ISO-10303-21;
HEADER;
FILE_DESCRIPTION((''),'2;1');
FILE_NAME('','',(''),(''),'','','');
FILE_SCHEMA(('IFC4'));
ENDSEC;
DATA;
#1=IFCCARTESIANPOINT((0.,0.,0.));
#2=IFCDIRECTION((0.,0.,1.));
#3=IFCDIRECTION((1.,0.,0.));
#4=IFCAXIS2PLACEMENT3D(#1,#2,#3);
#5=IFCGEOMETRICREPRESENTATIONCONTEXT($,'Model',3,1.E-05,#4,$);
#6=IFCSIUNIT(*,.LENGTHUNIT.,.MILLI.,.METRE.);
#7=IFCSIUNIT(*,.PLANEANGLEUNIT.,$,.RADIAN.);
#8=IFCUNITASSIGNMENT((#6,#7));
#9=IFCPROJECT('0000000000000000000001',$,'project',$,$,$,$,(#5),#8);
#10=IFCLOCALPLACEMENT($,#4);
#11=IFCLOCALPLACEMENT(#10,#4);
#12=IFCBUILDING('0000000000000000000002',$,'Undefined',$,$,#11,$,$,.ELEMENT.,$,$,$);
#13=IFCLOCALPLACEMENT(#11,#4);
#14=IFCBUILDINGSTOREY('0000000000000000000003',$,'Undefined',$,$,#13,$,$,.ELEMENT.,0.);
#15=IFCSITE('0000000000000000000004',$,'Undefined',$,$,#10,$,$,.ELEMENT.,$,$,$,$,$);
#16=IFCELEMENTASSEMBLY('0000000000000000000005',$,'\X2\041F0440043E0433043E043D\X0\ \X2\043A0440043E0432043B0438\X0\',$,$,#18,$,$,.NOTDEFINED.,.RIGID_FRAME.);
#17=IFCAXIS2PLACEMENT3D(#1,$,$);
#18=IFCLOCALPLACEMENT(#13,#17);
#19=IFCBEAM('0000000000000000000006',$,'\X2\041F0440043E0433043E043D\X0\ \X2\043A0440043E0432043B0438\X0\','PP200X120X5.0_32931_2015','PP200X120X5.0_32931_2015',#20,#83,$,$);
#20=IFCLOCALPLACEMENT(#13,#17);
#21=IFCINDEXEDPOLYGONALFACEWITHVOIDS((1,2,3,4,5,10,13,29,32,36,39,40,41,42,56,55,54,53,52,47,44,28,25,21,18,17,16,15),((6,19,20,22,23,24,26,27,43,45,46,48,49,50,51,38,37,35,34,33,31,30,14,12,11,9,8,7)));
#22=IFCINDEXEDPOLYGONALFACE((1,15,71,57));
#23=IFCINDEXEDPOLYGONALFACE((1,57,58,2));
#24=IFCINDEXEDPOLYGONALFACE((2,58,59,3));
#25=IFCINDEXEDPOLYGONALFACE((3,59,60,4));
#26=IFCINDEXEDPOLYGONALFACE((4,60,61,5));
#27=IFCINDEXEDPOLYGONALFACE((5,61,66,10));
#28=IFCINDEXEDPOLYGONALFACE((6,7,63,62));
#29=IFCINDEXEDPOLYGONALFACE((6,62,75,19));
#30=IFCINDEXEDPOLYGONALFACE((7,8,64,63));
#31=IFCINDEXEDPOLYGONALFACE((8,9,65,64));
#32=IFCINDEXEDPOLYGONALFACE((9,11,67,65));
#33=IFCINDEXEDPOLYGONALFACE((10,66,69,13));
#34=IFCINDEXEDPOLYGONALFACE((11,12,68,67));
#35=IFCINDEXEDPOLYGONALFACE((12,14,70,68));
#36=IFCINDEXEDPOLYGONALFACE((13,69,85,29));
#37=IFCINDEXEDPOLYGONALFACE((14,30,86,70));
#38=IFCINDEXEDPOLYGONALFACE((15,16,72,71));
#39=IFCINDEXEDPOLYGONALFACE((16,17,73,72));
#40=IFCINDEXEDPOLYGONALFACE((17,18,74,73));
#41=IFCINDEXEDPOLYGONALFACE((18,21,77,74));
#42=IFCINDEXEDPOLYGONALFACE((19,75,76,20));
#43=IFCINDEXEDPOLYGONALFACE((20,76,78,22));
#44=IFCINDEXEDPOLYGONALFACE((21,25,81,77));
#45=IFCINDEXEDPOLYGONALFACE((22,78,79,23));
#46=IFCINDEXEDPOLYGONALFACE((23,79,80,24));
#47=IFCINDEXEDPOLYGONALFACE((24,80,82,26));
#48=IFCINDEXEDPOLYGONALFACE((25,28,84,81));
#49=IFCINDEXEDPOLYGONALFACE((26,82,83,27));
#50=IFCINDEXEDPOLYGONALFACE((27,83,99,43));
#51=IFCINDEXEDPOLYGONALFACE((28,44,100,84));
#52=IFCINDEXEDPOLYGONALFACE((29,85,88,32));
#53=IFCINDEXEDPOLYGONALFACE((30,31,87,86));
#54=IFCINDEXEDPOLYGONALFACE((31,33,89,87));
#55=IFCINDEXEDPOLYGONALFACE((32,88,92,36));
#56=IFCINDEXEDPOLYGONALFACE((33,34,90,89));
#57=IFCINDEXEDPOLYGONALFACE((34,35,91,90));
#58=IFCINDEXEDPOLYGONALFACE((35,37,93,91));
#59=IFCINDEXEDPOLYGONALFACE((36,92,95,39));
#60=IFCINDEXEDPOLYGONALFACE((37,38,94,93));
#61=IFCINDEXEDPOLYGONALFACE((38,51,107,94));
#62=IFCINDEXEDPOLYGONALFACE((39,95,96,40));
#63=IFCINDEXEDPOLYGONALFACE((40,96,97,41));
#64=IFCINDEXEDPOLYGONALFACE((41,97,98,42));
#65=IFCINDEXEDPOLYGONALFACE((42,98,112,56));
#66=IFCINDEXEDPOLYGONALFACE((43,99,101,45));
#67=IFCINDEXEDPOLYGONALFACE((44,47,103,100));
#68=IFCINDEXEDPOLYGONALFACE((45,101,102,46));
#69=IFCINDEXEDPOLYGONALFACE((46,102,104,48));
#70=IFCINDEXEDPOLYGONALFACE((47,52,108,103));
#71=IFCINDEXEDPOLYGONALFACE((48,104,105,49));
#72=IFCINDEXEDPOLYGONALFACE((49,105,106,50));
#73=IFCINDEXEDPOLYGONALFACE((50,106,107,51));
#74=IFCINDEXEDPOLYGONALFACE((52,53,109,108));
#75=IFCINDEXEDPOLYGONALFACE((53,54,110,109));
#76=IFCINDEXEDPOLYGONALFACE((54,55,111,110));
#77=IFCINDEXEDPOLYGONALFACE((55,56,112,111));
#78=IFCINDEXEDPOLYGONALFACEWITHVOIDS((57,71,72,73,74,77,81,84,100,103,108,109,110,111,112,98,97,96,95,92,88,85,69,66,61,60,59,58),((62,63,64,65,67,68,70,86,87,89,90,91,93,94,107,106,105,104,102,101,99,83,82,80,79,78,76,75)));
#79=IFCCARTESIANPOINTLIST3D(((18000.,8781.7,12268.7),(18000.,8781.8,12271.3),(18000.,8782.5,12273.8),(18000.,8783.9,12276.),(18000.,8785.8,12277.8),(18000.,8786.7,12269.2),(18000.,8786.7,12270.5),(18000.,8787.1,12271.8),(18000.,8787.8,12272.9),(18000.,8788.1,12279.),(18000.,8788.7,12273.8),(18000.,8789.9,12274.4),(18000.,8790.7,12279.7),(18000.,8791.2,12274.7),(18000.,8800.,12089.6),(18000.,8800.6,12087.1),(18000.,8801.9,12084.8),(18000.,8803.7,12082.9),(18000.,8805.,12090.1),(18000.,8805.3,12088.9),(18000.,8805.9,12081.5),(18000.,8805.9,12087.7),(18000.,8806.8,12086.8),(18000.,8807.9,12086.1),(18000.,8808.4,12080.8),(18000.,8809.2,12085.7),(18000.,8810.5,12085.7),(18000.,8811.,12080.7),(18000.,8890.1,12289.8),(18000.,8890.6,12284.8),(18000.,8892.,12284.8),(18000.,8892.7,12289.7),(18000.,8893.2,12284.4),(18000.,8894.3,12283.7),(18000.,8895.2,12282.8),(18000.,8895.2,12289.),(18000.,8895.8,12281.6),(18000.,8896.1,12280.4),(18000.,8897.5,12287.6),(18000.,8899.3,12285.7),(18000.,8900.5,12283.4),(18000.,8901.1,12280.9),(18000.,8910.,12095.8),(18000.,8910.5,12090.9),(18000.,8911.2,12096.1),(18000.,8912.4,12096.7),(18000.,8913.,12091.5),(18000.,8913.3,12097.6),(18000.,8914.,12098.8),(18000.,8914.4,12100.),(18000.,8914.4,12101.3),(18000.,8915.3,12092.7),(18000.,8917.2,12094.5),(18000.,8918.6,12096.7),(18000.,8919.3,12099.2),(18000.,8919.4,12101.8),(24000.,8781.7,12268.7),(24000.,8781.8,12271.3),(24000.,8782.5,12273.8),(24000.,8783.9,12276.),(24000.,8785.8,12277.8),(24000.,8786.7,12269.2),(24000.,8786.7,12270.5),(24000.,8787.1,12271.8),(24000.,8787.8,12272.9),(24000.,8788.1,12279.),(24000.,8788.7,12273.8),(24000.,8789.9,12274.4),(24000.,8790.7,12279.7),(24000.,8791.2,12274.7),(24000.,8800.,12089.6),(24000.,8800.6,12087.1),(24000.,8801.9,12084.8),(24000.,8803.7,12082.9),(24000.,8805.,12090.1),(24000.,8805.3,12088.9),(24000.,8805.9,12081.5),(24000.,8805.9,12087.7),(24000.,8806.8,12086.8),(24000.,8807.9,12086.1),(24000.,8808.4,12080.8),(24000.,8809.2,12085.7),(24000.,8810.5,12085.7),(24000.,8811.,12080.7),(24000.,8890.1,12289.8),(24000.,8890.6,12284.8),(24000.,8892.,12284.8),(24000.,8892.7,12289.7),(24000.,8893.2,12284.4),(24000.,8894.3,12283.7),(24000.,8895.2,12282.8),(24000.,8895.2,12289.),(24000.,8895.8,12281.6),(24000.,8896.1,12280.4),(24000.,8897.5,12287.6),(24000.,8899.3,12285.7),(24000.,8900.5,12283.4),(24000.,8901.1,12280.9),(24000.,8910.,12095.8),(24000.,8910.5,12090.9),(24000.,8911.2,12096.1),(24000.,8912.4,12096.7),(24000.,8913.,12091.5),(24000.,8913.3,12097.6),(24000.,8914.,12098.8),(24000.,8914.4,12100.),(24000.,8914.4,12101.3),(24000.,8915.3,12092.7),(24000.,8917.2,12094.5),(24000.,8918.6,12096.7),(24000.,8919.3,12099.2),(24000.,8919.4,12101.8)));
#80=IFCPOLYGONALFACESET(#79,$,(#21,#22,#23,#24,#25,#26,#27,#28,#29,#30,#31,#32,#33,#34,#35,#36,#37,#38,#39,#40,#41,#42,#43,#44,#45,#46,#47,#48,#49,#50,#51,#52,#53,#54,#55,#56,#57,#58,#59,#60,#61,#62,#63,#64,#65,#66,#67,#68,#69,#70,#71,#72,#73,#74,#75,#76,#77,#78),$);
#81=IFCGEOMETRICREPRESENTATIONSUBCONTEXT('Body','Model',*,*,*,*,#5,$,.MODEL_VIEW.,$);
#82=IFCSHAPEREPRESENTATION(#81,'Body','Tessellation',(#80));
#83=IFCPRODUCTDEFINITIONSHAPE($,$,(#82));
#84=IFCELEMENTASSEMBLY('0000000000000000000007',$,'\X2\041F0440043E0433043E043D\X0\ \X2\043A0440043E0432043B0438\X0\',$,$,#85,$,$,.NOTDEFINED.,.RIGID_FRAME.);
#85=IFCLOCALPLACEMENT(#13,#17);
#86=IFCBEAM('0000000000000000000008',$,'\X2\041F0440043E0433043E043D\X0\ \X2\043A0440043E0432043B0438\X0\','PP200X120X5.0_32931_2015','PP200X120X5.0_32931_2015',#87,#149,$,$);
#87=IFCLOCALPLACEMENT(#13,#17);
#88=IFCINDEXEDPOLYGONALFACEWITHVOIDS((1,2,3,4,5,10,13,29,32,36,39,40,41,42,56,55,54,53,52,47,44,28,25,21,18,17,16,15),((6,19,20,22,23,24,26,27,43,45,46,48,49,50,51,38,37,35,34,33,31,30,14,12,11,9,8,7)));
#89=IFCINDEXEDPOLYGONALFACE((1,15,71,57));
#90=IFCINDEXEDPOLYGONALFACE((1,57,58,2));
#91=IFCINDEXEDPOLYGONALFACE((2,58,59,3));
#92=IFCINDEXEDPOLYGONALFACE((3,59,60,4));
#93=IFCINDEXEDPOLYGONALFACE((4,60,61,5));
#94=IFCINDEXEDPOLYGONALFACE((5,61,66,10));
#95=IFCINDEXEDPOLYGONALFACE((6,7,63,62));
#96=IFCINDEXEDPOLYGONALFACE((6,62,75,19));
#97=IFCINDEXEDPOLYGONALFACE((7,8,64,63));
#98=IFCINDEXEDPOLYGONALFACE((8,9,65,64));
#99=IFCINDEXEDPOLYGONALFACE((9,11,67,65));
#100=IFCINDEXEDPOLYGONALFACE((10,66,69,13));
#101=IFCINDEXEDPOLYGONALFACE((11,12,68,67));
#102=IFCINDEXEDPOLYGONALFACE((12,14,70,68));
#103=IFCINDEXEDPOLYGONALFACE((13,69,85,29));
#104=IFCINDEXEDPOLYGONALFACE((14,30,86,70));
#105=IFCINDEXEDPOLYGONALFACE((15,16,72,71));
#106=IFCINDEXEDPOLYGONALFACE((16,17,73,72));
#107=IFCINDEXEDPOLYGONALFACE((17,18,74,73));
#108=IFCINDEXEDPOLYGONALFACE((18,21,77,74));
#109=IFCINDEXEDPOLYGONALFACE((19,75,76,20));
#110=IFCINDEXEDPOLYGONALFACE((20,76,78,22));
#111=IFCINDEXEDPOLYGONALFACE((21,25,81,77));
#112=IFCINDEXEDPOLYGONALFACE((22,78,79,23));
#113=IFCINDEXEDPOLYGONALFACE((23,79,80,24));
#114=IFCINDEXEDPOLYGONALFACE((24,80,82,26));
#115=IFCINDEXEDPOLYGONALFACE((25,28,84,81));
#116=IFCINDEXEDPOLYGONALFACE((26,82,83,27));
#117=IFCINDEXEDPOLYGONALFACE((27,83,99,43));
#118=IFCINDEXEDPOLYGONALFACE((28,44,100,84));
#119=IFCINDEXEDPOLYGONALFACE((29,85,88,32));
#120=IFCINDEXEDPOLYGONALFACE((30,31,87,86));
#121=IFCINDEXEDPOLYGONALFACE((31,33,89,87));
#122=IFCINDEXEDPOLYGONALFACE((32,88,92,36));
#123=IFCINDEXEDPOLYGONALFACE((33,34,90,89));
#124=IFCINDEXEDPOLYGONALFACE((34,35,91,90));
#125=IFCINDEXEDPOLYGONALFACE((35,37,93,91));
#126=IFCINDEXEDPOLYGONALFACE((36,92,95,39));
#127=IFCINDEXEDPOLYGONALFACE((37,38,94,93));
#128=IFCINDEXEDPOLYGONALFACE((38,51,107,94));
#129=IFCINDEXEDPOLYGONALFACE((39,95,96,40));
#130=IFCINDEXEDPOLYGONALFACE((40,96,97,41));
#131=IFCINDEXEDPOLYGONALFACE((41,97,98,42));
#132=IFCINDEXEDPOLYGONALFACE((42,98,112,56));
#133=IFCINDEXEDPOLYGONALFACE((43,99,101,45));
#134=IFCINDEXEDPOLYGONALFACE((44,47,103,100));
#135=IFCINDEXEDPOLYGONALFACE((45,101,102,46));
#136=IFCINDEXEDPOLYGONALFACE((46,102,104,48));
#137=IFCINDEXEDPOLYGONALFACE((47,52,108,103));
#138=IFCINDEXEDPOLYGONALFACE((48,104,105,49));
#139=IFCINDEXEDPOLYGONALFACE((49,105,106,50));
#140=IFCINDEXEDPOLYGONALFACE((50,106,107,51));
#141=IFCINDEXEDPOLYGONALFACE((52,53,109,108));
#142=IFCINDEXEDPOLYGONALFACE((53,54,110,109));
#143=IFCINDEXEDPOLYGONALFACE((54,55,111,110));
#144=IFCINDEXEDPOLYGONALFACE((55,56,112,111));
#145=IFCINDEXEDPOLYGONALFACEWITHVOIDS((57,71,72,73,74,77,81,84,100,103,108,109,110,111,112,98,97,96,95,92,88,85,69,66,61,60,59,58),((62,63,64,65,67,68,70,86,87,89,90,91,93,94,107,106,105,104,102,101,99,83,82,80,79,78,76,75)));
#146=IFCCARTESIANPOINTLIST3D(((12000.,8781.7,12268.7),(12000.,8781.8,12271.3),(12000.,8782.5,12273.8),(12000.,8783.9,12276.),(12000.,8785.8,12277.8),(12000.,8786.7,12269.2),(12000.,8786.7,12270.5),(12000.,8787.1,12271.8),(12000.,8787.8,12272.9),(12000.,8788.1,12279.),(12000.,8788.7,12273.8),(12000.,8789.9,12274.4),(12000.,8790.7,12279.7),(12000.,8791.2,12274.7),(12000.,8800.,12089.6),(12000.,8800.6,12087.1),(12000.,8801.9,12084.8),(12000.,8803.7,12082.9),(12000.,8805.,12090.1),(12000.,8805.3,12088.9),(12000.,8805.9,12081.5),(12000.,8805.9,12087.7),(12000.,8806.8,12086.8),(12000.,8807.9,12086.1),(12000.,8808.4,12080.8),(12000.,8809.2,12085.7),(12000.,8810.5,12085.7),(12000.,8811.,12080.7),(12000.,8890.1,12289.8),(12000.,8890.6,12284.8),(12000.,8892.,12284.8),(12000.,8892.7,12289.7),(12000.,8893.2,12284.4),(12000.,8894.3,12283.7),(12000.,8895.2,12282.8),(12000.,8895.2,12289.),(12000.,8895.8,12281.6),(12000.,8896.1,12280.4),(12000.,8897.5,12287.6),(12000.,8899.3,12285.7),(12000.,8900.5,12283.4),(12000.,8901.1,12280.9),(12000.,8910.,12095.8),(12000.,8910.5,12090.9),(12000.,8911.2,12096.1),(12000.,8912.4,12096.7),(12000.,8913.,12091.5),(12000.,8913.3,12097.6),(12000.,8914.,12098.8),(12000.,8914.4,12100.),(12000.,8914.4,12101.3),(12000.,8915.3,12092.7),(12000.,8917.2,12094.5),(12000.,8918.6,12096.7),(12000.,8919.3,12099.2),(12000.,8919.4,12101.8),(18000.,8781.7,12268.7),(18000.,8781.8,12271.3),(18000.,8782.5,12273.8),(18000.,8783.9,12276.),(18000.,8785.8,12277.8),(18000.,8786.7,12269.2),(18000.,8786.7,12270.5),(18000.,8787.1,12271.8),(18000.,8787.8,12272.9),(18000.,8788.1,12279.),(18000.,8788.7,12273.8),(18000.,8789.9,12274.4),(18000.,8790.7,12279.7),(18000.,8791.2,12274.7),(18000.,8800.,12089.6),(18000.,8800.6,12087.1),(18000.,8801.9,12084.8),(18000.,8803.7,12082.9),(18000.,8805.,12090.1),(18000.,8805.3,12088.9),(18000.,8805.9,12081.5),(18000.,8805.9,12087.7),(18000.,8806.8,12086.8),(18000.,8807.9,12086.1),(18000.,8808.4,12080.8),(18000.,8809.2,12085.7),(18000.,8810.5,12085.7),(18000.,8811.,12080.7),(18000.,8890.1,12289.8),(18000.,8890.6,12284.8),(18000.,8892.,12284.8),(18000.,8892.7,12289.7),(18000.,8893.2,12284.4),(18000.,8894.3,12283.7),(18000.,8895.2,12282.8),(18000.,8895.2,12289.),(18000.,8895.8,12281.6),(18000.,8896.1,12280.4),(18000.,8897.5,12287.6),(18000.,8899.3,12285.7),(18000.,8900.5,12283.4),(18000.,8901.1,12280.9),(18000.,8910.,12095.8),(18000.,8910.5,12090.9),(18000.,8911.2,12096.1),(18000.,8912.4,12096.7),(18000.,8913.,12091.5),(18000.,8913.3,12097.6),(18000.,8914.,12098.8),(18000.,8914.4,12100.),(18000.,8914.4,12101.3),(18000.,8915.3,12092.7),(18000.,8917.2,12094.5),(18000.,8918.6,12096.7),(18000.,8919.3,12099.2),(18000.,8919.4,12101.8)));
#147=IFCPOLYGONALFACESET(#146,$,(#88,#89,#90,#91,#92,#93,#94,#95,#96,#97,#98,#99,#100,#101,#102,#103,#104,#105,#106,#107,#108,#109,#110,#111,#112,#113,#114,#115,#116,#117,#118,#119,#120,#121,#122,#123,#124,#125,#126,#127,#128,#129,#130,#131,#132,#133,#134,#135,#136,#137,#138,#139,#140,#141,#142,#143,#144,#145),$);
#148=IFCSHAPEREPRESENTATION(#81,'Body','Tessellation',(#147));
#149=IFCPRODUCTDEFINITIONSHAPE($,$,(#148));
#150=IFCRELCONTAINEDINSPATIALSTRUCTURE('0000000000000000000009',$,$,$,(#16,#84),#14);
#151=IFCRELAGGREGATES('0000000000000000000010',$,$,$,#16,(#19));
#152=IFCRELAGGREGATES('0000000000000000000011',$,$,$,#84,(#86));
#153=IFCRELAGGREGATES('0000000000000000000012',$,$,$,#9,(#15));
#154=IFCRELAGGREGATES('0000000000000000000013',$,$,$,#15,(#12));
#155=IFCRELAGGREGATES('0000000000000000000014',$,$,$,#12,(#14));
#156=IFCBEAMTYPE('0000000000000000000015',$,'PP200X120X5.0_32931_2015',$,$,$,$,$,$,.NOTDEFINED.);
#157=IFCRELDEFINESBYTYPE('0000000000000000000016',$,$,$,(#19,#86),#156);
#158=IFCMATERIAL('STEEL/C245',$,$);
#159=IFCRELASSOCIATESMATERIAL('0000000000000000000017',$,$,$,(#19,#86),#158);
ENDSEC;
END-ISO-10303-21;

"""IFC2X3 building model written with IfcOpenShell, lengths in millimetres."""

from ifc_helpers import new_model, si_unit, frame, origin_with_axes, origin_2d_with_axis, place, context, subcontext, project, spatial, hollow_rectangle, extrude, material, type_object, element, aggregate, save


model = new_model("IFC2X3")

# Units and contexts
model_context = context("Model", 3, precision=1e-05, world=origin_with_axes())
body_context = subcontext(model_context, "Body", "Model", "MODEL_VIEW")
ifc_project = project(units=[si_unit("LENGTHUNIT", "METRE", prefix="MILLI"), si_unit("PLANEANGLEUNIT", "RADIAN")], contexts=[model_context])

# Site, building, storey
site_placement = place(None, origin_with_axes())
site = spatial("IfcSite", under=ifc_project, at=site_placement, Name="Undefined", CompositionType="ELEMENT")
building_placement = place(site_placement, origin_with_axes())
building = spatial("IfcBuilding", under=site, at=building_placement, Name="Undefined", CompositionType="ELEMENT")
storey_placement = place(building_placement, origin_with_axes())
storey = spatial("IfcBuildingStorey", under=building, at=storey_placement, Name="Undefined", CompositionType="ELEMENT", Elevation=0.0)

# Element assemblies, beams
assembly_1_placement = place(storey_placement, origin_with_axes())
assembly_1 = element("IfcElementAssembly", 1, at=assembly_1_placement, inside=storey, Name="Прогон кровли", AssemblyPlace="NOTDEFINED", PredefinedType="RIGID_FRAME")
ifc_material_1 = material(Name="STEEL/C245")
beam_type_1 = type_object("IfcBeamType", Name="PP200X120X5.0_32931_2015", PredefinedType="NOTDEFINED")
beam_1_placement = place(assembly_1_placement, frame((24000.0, 8850.6, 12185.3), z_axis=(0.0, -0.101645, 0.994821), x_axis=(-1.0, 0.0, 0.0)))
beam_1 = element("IfcBeam", 2, at=beam_1_placement, type_object=beam_type_1, material=ifc_material_1, Name="Прогон кровли", Description="PP200X120X5.0_32931_2015", ObjectType="PP200X120X5.0_32931_2015", context=body_context, shape_type="SweptSolid", body=[
    extrude(hollow_rectangle(XDim=120.0, YDim=200.0, WallThickness=5.0, InnerFilletRadius=5.0, OuterFilletRadius=10.0, at=origin_2d_with_axis()), frame((6000.0, 0.0, 0.0), z_axis=(-1.0, 0.0, 0.0), x_axis=(0.0, -1.0, 0.0)), (0.0, 0.0, 1.0), 6000.0),
])
aggregate(assembly_1, [beam_1])
assembly_2_placement = place(storey_placement, origin_with_axes())
assembly_2 = element("IfcElementAssembly", 3, at=assembly_2_placement, inside=storey, Name="Прогон кровли", AssemblyPlace="NOTDEFINED", PredefinedType="RIGID_FRAME")
beam_2_placement = place(assembly_2_placement, frame((18000.0, 8850.6, 12185.3), z_axis=(0.0, -0.101645, 0.994821), x_axis=(-1.0, 0.0, 0.0)))
beam_2 = element("IfcBeam", 4, at=beam_2_placement, type_object=beam_type_1, material=ifc_material_1, Name="Прогон кровли", Description="PP200X120X5.0_32931_2015", ObjectType="PP200X120X5.0_32931_2015", context=body_context, shape_type="SweptSolid", body=[
    extrude(hollow_rectangle(XDim=120.0, YDim=200.0, WallThickness=5.0, InnerFilletRadius=5.0, OuterFilletRadius=10.0, at=origin_2d_with_axis()), frame((6000.0, 0.0, 0.0), z_axis=(-1.0, 0.0, 0.0), x_axis=(0.0, -1.0, 0.0)), (0.0, 0.0, 1.0), 6000.0),
])
aggregate(assembly_2, [beam_2])

save(model, "model.ifc")
